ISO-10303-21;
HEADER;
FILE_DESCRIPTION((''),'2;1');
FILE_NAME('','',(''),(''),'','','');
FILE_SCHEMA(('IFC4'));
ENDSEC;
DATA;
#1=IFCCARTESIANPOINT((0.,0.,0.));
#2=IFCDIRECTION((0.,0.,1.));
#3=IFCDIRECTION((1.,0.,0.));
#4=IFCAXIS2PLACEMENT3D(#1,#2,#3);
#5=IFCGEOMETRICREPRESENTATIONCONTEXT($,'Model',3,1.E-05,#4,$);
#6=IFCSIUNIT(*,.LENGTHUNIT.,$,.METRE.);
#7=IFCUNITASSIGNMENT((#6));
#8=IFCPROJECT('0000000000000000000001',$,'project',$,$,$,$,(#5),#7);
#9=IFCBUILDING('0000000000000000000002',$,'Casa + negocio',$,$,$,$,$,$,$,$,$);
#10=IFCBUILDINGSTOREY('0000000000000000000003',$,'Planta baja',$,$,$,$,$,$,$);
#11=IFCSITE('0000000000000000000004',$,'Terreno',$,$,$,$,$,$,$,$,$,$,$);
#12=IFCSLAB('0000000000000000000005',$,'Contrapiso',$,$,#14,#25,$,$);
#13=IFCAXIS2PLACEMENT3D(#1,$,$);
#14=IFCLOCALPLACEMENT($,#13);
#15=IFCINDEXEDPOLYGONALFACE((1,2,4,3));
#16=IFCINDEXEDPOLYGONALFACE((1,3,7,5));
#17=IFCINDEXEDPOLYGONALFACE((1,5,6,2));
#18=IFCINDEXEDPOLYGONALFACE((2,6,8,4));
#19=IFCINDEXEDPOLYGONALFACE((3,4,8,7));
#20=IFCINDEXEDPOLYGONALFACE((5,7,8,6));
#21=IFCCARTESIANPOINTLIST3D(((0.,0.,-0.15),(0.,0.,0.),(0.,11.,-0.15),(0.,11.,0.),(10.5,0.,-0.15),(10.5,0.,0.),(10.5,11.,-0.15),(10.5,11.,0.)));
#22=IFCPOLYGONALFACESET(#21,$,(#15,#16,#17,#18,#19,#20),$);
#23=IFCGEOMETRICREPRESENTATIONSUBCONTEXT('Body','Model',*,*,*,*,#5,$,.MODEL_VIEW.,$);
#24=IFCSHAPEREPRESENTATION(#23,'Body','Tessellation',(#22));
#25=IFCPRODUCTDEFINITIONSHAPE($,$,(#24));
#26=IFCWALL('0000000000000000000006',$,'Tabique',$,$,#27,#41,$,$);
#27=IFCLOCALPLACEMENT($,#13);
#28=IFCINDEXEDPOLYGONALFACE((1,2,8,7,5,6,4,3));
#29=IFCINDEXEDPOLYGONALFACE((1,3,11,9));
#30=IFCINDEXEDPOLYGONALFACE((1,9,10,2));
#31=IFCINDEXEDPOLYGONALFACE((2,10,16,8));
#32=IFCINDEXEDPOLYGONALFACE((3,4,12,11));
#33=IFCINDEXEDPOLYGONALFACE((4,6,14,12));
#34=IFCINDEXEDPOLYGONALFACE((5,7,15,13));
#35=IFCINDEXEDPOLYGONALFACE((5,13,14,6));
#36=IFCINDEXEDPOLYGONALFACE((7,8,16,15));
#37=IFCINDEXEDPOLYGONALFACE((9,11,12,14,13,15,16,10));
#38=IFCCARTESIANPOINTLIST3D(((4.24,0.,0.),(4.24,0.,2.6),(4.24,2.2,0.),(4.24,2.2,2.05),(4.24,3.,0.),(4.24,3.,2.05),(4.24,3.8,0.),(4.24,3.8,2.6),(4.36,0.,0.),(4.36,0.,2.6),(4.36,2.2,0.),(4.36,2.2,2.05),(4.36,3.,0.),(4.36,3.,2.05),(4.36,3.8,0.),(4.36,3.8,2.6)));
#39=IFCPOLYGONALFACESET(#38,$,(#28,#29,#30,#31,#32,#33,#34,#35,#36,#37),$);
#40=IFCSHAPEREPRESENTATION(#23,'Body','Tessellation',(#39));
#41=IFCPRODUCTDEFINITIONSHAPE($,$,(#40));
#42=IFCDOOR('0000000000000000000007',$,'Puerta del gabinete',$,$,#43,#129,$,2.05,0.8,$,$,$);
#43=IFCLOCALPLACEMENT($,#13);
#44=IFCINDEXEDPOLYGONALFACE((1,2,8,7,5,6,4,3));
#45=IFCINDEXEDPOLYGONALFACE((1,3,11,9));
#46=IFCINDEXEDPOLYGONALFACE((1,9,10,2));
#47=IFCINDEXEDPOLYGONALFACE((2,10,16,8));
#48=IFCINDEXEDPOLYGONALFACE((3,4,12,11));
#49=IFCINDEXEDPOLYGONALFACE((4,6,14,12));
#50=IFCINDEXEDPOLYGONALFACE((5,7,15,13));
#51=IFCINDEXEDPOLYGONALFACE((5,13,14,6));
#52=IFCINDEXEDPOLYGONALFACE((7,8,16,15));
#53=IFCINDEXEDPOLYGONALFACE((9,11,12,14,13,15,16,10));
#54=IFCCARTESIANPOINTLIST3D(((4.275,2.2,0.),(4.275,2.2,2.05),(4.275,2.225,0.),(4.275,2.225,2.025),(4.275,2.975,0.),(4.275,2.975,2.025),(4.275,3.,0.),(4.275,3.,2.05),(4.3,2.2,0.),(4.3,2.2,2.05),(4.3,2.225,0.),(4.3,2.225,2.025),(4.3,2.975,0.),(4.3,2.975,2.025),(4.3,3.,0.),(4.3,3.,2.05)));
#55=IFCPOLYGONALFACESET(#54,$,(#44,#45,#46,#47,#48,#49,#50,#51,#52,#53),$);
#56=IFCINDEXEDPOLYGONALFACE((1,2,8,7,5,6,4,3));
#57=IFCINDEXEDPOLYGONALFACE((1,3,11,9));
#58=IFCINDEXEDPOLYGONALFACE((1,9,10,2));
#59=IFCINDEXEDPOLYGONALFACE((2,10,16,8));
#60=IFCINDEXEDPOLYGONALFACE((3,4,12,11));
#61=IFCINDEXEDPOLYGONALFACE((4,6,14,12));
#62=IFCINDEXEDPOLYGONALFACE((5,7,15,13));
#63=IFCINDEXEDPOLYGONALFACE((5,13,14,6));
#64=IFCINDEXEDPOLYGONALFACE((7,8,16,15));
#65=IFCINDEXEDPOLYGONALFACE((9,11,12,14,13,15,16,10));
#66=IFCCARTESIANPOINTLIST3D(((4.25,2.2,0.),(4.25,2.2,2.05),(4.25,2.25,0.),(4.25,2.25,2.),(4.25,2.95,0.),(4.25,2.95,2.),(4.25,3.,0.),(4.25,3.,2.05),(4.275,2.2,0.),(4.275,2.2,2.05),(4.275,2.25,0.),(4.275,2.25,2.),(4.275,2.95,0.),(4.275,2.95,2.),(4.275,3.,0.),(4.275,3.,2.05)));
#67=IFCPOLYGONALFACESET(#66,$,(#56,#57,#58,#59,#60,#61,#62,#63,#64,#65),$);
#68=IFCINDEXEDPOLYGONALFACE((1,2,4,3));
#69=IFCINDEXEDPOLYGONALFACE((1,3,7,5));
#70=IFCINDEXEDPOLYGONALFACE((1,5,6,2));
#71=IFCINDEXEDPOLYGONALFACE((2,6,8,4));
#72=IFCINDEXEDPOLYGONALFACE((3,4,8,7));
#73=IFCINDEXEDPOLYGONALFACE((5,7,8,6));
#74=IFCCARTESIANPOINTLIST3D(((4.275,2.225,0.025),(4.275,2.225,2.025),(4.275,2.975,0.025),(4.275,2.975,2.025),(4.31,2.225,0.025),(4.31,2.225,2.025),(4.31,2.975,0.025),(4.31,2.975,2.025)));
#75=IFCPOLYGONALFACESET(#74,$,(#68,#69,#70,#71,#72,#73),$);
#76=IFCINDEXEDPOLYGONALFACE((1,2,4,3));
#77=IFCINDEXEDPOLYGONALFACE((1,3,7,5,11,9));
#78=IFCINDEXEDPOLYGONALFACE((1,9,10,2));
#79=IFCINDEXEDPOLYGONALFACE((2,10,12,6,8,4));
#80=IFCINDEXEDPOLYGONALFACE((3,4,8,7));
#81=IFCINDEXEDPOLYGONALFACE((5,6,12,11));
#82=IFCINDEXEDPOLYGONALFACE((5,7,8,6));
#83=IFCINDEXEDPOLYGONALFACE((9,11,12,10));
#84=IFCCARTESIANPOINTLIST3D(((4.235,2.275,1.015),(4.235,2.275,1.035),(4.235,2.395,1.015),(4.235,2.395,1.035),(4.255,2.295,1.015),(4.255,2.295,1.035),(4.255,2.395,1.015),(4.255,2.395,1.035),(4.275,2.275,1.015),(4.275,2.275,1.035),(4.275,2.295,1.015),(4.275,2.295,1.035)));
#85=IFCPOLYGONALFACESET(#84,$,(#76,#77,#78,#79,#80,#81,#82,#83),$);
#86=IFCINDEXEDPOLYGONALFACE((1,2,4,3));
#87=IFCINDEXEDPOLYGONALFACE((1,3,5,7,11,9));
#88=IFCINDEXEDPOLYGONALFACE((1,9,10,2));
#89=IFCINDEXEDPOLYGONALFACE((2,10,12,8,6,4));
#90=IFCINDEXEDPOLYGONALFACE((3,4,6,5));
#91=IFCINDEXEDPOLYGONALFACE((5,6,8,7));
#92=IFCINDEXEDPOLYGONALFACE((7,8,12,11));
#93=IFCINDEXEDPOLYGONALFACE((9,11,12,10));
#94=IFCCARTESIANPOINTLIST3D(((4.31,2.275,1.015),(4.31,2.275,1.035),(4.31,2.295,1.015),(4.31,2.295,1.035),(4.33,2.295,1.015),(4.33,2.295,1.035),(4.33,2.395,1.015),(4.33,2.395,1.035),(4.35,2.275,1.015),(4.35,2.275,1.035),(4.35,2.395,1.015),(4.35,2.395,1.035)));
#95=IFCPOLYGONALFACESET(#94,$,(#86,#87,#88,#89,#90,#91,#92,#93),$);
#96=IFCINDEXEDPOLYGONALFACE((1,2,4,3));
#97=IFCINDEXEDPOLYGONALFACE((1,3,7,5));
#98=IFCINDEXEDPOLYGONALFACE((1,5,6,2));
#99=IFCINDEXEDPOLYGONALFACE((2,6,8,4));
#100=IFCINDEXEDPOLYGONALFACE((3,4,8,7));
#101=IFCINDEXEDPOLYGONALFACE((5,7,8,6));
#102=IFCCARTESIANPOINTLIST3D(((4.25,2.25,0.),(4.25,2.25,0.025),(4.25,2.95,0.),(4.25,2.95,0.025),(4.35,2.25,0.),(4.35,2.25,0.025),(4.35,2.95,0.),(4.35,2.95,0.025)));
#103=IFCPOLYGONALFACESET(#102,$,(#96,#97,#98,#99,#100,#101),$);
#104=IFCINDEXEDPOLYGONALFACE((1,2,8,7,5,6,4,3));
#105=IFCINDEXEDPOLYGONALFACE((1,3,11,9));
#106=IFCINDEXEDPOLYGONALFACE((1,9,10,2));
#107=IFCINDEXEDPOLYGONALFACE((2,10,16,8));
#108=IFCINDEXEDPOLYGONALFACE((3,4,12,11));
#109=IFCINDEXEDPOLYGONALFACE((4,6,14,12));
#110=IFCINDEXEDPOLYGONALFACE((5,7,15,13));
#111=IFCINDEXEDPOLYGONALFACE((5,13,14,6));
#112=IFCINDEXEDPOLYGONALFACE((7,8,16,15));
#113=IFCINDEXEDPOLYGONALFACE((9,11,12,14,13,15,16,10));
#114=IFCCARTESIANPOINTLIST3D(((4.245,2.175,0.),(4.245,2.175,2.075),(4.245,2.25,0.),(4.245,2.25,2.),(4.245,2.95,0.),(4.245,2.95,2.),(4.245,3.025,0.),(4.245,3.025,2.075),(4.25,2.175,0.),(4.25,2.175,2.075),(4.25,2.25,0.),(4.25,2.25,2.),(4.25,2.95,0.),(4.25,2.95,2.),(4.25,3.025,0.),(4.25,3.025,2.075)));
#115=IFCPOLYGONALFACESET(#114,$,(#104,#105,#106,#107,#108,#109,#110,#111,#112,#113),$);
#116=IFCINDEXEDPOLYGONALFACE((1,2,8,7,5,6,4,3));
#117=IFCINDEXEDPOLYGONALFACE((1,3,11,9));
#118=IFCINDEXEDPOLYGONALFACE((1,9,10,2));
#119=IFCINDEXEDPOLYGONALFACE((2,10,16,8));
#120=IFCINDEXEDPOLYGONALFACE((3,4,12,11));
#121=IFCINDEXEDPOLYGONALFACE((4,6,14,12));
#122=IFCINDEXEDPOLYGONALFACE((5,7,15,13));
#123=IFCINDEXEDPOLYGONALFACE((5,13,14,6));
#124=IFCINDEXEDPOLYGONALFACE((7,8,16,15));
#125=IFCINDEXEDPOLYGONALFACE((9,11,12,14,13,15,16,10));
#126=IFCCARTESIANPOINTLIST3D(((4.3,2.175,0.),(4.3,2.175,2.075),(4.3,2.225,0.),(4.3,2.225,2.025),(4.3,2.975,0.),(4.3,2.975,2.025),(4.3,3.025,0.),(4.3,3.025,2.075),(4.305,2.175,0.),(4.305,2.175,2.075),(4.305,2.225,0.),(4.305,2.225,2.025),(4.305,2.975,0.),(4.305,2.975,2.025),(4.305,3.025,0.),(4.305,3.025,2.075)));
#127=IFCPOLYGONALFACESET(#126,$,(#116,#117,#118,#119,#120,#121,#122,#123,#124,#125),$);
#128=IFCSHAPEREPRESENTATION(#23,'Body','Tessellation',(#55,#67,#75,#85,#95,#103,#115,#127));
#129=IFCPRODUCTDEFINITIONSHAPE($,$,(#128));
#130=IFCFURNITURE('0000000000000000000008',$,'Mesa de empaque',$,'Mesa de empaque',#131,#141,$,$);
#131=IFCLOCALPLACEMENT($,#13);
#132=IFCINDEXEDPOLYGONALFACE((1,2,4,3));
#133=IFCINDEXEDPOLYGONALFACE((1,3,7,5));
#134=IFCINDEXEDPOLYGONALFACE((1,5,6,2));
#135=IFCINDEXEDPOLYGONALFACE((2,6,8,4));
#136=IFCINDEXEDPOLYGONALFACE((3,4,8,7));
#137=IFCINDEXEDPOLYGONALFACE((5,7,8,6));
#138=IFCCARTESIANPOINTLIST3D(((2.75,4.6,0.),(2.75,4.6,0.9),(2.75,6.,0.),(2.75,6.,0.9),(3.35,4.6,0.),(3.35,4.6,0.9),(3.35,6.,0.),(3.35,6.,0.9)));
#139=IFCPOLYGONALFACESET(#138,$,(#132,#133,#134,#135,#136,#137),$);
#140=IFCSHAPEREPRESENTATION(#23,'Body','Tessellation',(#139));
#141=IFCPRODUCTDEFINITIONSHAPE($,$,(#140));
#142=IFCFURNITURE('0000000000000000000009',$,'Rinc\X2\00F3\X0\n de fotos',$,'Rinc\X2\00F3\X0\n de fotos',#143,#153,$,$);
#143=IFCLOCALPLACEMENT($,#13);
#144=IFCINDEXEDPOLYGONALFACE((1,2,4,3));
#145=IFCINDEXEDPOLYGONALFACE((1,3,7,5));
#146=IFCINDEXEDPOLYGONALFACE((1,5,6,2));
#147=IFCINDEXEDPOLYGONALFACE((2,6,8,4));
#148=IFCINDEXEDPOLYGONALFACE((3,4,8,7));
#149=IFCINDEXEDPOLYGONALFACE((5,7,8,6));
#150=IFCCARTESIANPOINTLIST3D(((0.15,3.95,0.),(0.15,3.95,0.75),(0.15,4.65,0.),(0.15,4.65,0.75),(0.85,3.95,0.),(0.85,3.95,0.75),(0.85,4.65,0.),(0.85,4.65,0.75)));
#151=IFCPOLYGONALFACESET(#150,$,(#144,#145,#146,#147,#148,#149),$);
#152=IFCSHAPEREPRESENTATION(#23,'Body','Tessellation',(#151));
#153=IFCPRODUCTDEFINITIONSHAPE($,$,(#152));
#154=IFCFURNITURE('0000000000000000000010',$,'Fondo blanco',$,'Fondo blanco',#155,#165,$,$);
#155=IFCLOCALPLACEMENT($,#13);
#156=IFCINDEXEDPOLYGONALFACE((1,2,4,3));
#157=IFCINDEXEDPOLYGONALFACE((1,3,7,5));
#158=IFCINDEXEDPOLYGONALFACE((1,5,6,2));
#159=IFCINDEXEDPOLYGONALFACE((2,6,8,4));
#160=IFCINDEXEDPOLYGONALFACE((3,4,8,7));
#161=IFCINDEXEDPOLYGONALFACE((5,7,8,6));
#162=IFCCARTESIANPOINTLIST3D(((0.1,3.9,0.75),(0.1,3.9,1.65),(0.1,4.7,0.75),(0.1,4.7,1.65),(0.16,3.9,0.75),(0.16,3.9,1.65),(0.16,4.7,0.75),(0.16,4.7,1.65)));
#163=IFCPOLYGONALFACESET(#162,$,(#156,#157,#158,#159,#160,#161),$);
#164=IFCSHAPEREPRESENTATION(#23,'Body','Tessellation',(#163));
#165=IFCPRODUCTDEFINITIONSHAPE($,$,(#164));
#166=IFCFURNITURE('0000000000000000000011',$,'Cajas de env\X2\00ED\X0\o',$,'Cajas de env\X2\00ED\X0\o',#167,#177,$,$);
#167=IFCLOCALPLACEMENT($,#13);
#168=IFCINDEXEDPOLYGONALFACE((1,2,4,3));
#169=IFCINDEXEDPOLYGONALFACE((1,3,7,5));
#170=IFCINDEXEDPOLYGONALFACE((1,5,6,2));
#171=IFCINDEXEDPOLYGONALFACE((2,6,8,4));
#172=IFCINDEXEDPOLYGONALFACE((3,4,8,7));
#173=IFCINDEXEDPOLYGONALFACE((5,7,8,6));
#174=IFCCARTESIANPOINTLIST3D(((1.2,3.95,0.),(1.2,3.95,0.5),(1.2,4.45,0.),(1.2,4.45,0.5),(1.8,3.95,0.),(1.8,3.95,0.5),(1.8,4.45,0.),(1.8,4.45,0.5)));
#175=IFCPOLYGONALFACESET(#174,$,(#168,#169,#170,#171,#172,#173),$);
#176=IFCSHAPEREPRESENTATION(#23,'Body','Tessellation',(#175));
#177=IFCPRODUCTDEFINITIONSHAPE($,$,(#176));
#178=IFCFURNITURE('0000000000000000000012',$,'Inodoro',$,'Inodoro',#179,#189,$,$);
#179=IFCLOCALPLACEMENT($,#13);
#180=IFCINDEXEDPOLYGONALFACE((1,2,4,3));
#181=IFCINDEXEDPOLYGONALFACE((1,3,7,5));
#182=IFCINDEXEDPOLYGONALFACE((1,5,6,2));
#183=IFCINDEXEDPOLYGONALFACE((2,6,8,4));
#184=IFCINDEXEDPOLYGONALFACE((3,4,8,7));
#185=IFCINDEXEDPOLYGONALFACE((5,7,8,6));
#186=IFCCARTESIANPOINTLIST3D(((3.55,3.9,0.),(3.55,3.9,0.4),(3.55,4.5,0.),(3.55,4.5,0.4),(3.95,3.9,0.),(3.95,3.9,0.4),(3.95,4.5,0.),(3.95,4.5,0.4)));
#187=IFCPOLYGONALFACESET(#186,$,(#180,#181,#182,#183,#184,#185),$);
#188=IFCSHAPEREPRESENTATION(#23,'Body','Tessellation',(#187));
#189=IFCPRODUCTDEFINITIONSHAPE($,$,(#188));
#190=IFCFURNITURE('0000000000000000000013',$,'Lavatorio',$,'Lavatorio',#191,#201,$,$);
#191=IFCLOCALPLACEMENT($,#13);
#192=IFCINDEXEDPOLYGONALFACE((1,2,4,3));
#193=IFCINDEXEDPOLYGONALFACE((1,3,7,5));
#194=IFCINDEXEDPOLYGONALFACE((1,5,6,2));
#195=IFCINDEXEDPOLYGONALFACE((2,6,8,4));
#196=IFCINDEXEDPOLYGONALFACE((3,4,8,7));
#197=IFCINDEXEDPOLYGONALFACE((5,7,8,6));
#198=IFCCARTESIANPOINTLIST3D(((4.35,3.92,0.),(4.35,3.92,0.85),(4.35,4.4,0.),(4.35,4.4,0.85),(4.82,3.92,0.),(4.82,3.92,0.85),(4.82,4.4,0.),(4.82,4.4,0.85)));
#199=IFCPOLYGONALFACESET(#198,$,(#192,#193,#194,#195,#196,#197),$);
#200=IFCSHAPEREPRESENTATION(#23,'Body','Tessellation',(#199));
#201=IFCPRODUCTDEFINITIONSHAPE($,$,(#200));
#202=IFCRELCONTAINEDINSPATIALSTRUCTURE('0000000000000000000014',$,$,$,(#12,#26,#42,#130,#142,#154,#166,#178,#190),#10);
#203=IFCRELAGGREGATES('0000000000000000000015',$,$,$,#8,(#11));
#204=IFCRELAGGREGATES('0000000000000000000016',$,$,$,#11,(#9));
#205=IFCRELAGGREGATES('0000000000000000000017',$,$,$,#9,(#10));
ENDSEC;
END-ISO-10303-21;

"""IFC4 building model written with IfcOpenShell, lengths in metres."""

from ifc_helpers import new_model, si_unit, frame, origin_with_axes, place, context, subcontext, project, spatial, line, indexed_curve, outline, extrude, element, fill, save


model = new_model("IFC4")

# Units and contexts
model_context = context("Model", 3, precision=1e-05, world=origin_with_axes())
body_context = subcontext(model_context, "Body", "Model", "MODEL_VIEW")
ifc_project = project(units=[si_unit("LENGTHUNIT", "METRE")], contexts=[model_context])

# Site, building, storey
site = spatial("IfcSite", under=ifc_project, Name="Terreno")
building = spatial("IfcBuilding", under=site, Name="Casa + negocio")
storey = spatial("IfcBuildingStorey", under=building, Name="Planta baja")

# Slab
slab_placement = place(None, frame((0.0, 0.0, -0.15), z_axis=(0.0, 0.0, 1.0), x_axis=(1.0, 0.0, 0.0)))
element("IfcSlab", 1, at=slab_placement, inside=storey, Name="Contrapiso", context=body_context, shape_type="SweptSolid", body=[
    extrude(outline(indexed_curve([(0.0, 0.0), (10.5, 0.0), (10.5, 11.0), (0.0, 11.0)], segments=[line(1, 2, 3, 4, 1)])), origin_with_axes(), (0.0, 0.0, 1.0), 0.15),
])

# Wall, opening, door
wall_1_placement = place(None, frame((4.3, 3.8, 0.0), z_axis=(0.0, 0.0, 1.0), x_axis=(0.0, -1.0, 0.0)))
wall_1 = element("IfcWall", 2, at=wall_1_placement, inside=storey, Name="Tabique", context=body_context, shape_type="SweptSolid", body=[
    extrude(outline(indexed_curve([(0.0, 0.0), (0.0, 0.12), (3.8, 0.12), (3.8, 0.0), (0.0, 0.0)], self_intersect=False)), frame((0.0, -0.06, 0.0), z_axis=(0.0, 0.0, 1.0), x_axis=(1.0, 0.0, 0.0)), (0.0, 0.0, 1.0), 2.6),
])
opening_1_placement = place(wall_1_placement, frame((0.8, 0.0, 0.0), z_axis=(0.0, 0.0, 1.0), x_axis=(1.0, 0.0, 0.0)))
opening_1 = element("IfcOpeningElement", 3, at=opening_1_placement, cuts=wall_1, context=body_context, shape_type="SweptSolid", body=[
    extrude(outline(indexed_curve([(0.0, 0.0), (0.0, 0.22), (0.8, 0.22), (0.8, 0.0), (0.0, 0.0)], self_intersect=False)), frame((0.0, -0.11, 0.0), z_axis=(0.0, 0.0, 1.0), x_axis=(1.0, 0.0, 0.0)), (0.0, 0.0, 1.0), 2.05),
])
door_1_placement = place(opening_1_placement, frame((0.0, -0.05, 0.0), z_axis=(0.0, 0.0, 1.0), x_axis=(1.0, 0.0, 0.0)))
door_1 = element("IfcDoor", 4, at=door_1_placement, inside=storey, Name="Puerta del gabinete", OverallHeight=2.05, OverallWidth=0.8, context=body_context, shape_type="SweptSolid", body=[
    extrude(outline(indexed_curve([(0.0, 0.0), (0.0, 2.05), (0.8, 2.05), (0.8, 0.0), (0.775, 0.0), (0.775, 2.025), (0.025, 2.025), (0.025, 0.0)], segments=[line(1, 2, 3, 4, 5, 6, 7, 8, 1)])), frame((0.0, 0.025, 0.0), z_axis=(0.0, -1.0, 0.0), x_axis=(1.0, 0.0, 0.0)), (0.0, 0.0, -1.0), 0.025),
    extrude(outline(indexed_curve([(0.0, 0.0), (0.0, 2.05), (0.8, 2.05), (0.8, 0.0), (0.75, 0.0), (0.75, 2.0), (0.05, 2.0), (0.05, 0.0)], segments=[line(1, 2, 3, 4, 5, 6, 7, 8, 1)])), frame((0.0, 0.0, 0.0), z_axis=(0.0, -1.0, 0.0), x_axis=(1.0, 0.0, 0.0)), (0.0, 0.0, -1.0), 0.025),
    extrude(outline(indexed_curve([(0.0, 0.0), (0.75, 0.0), (0.75, 0.035), (0.0, 0.035)], segments=[line(1, 2, 3, 4, 1)])), frame((0.025, 0.025, 0.025), z_axis=(0.0, 0.0, 1.0), x_axis=(1.0, 0.0, 0.0)), (0.0, 0.0, 1.0), 2.0),
    extrude(outline(indexed_curve([(0.0, 0.0), (0.0, -0.04), (-0.12, -0.04), (-0.12, -0.02), (-0.02, -0.02), (-0.02, 0.0)], segments=[line(1, 2, 3, 4, 5, 6, 1)])), frame((0.725, 0.025, 1.015), z_axis=(0.0, 0.0, 1.0), x_axis=(1.0, 0.0, 0.0)), (0.0, 0.0, 1.0), 0.02),
    extrude(outline(indexed_curve([(0.0, 0.0), (0.0, 0.04), (-0.12, 0.04), (-0.12, 0.02), (-0.02, 0.02), (-0.02, 0.0)], segments=[line(1, 2, 3, 4, 5, 6, 1)])), frame((0.725, 0.06, 1.015), z_axis=(0.0, 0.0, 1.0), x_axis=(1.0, 0.0, 0.0)), (0.0, 0.0, 1.0), 0.02),
    extrude(outline(indexed_curve([(0.0, 0.0), (0.7, 0.0), (0.7, 0.1), (0.0, 0.1)], segments=[line(1, 2, 3, 4, 1)])), frame((0.05, 0.0, 0.0), z_axis=(0.0, 0.0, 1.0), x_axis=(1.0, 0.0, 0.0)), (0.0, 0.0, 1.0), 0.025),
    extrude(outline(indexed_curve([(0.0, 0.0), (0.0, 2.075), (0.85, 2.075), (0.85, 0.0), (0.775, 0.0), (0.775, 2.0), (0.075, 2.0), (0.075, 0.0)], segments=[line(1, 2, 3, 4, 5, 6, 7, 8, 1)])), frame((-0.025, -0.005, 0.0), z_axis=(0.0, -1.0, 0.0), x_axis=(1.0, 0.0, 0.0)), (0.0, 0.0, -1.0), 0.005),
    extrude(outline(indexed_curve([(0.0, 0.0), (0.0, 2.075), (0.85, 2.075), (0.85, 0.0), (0.8, 0.0), (0.8, 2.025), (0.05, 2.025), (0.05, 0.0)], segments=[line(1, 2, 3, 4, 5, 6, 7, 8, 1)])), frame((-0.025, 0.05, 0.0), z_axis=(0.0, -1.0, 0.0), x_axis=(1.0, 0.0, 0.0)), (0.0, 0.0, -1.0), 0.005),
])
fill(opening_1, door_1)

# Furniture
furniture_1_placement = place(None, frame((2.75, 4.6, 0.0), z_axis=(0.0, 0.0, 1.0), x_axis=(1.0, 0.0, 0.0)))
element("IfcFurniture", 5, at=furniture_1_placement, inside=storey, Name="Mesa de empaque", ObjectType="Mesa de empaque", context=body_context, shape_type="SweptSolid", body=[
    extrude(outline(indexed_curve([(0.0, 0.0), (0.6, 0.0), (0.6, 1.4), (0.0, 1.4)], segments=[line(1, 2, 3, 4, 1)])), origin_with_axes(), (0.0, 0.0, 1.0), 0.9),
])
furniture_2_placement = place(None, frame((0.15, 3.95, 0.0), z_axis=(0.0, 0.0, 1.0), x_axis=(1.0, 0.0, 0.0)))
element("IfcFurniture", 6, at=furniture_2_placement, inside=storey, Name="Rincón de fotos", ObjectType="Rincón de fotos", context=body_context, shape_type="SweptSolid", body=[
    extrude(outline(indexed_curve([(0.0, 0.0), (0.7, 0.0), (0.7, 0.7), (0.0, 0.7)], segments=[line(1, 2, 3, 4, 1)])), origin_with_axes(), (0.0, 0.0, 1.0), 0.75),
])
furniture_3_placement = place(None, frame((0.1, 3.9, 0.75), z_axis=(0.0, 0.0, 1.0), x_axis=(1.0, 0.0, 0.0)))
element("IfcFurniture", 7, at=furniture_3_placement, inside=storey, Name="Fondo blanco", ObjectType="Fondo blanco", context=body_context, shape_type="SweptSolid", body=[
    extrude(outline(indexed_curve([(0.0, 0.0), (0.06, 0.0), (0.06, 0.8), (0.0, 0.8)], segments=[line(1, 2, 3, 4, 1)])), origin_with_axes(), (0.0, 0.0, 1.0), 0.9),
])
furniture_4_placement = place(None, frame((1.2, 3.95, 0.0), z_axis=(0.0, 0.0, 1.0), x_axis=(1.0, 0.0, 0.0)))
element("IfcFurniture", 8, at=furniture_4_placement, inside=storey, Name="Cajas de envío", ObjectType="Cajas de envío", context=body_context, shape_type="SweptSolid", body=[
    extrude(outline(indexed_curve([(0.0, 0.0), (0.6, 0.0), (0.6, 0.5), (0.0, 0.5)], segments=[line(1, 2, 3, 4, 1)])), origin_with_axes(), (0.0, 0.0, 1.0), 0.5),
])
furniture_5_placement = place(None, frame((3.55, 3.9, 0.0), z_axis=(0.0, 0.0, 1.0), x_axis=(1.0, 0.0, 0.0)))
element("IfcFurniture", 9, at=furniture_5_placement, inside=storey, Name="Inodoro", ObjectType="Inodoro", context=body_context, shape_type="SweptSolid", body=[
    extrude(outline(indexed_curve([(0.0, 0.0), (0.4, 0.0), (0.4, 0.6), (0.0, 0.6)], segments=[line(1, 2, 3, 4, 1)])), origin_with_axes(), (0.0, 0.0, 1.0), 0.4),
])
furniture_6_placement = place(None, frame((4.35, 3.92, 0.0), z_axis=(0.0, 0.0, 1.0), x_axis=(1.0, 0.0, 0.0)))
element("IfcFurniture", 10, at=furniture_6_placement, inside=storey, Name="Lavatorio", ObjectType="Lavatorio", context=body_context, shape_type="SweptSolid", body=[
    extrude(outline(indexed_curve([(0.0, 0.0), (0.47, 0.0), (0.47, 0.48), (0.0, 0.48)], segments=[line(1, 2, 3, 4, 1)])), origin_with_axes(), (0.0, 0.0, 1.0), 0.85),
])

save(model, "model.ifc")
